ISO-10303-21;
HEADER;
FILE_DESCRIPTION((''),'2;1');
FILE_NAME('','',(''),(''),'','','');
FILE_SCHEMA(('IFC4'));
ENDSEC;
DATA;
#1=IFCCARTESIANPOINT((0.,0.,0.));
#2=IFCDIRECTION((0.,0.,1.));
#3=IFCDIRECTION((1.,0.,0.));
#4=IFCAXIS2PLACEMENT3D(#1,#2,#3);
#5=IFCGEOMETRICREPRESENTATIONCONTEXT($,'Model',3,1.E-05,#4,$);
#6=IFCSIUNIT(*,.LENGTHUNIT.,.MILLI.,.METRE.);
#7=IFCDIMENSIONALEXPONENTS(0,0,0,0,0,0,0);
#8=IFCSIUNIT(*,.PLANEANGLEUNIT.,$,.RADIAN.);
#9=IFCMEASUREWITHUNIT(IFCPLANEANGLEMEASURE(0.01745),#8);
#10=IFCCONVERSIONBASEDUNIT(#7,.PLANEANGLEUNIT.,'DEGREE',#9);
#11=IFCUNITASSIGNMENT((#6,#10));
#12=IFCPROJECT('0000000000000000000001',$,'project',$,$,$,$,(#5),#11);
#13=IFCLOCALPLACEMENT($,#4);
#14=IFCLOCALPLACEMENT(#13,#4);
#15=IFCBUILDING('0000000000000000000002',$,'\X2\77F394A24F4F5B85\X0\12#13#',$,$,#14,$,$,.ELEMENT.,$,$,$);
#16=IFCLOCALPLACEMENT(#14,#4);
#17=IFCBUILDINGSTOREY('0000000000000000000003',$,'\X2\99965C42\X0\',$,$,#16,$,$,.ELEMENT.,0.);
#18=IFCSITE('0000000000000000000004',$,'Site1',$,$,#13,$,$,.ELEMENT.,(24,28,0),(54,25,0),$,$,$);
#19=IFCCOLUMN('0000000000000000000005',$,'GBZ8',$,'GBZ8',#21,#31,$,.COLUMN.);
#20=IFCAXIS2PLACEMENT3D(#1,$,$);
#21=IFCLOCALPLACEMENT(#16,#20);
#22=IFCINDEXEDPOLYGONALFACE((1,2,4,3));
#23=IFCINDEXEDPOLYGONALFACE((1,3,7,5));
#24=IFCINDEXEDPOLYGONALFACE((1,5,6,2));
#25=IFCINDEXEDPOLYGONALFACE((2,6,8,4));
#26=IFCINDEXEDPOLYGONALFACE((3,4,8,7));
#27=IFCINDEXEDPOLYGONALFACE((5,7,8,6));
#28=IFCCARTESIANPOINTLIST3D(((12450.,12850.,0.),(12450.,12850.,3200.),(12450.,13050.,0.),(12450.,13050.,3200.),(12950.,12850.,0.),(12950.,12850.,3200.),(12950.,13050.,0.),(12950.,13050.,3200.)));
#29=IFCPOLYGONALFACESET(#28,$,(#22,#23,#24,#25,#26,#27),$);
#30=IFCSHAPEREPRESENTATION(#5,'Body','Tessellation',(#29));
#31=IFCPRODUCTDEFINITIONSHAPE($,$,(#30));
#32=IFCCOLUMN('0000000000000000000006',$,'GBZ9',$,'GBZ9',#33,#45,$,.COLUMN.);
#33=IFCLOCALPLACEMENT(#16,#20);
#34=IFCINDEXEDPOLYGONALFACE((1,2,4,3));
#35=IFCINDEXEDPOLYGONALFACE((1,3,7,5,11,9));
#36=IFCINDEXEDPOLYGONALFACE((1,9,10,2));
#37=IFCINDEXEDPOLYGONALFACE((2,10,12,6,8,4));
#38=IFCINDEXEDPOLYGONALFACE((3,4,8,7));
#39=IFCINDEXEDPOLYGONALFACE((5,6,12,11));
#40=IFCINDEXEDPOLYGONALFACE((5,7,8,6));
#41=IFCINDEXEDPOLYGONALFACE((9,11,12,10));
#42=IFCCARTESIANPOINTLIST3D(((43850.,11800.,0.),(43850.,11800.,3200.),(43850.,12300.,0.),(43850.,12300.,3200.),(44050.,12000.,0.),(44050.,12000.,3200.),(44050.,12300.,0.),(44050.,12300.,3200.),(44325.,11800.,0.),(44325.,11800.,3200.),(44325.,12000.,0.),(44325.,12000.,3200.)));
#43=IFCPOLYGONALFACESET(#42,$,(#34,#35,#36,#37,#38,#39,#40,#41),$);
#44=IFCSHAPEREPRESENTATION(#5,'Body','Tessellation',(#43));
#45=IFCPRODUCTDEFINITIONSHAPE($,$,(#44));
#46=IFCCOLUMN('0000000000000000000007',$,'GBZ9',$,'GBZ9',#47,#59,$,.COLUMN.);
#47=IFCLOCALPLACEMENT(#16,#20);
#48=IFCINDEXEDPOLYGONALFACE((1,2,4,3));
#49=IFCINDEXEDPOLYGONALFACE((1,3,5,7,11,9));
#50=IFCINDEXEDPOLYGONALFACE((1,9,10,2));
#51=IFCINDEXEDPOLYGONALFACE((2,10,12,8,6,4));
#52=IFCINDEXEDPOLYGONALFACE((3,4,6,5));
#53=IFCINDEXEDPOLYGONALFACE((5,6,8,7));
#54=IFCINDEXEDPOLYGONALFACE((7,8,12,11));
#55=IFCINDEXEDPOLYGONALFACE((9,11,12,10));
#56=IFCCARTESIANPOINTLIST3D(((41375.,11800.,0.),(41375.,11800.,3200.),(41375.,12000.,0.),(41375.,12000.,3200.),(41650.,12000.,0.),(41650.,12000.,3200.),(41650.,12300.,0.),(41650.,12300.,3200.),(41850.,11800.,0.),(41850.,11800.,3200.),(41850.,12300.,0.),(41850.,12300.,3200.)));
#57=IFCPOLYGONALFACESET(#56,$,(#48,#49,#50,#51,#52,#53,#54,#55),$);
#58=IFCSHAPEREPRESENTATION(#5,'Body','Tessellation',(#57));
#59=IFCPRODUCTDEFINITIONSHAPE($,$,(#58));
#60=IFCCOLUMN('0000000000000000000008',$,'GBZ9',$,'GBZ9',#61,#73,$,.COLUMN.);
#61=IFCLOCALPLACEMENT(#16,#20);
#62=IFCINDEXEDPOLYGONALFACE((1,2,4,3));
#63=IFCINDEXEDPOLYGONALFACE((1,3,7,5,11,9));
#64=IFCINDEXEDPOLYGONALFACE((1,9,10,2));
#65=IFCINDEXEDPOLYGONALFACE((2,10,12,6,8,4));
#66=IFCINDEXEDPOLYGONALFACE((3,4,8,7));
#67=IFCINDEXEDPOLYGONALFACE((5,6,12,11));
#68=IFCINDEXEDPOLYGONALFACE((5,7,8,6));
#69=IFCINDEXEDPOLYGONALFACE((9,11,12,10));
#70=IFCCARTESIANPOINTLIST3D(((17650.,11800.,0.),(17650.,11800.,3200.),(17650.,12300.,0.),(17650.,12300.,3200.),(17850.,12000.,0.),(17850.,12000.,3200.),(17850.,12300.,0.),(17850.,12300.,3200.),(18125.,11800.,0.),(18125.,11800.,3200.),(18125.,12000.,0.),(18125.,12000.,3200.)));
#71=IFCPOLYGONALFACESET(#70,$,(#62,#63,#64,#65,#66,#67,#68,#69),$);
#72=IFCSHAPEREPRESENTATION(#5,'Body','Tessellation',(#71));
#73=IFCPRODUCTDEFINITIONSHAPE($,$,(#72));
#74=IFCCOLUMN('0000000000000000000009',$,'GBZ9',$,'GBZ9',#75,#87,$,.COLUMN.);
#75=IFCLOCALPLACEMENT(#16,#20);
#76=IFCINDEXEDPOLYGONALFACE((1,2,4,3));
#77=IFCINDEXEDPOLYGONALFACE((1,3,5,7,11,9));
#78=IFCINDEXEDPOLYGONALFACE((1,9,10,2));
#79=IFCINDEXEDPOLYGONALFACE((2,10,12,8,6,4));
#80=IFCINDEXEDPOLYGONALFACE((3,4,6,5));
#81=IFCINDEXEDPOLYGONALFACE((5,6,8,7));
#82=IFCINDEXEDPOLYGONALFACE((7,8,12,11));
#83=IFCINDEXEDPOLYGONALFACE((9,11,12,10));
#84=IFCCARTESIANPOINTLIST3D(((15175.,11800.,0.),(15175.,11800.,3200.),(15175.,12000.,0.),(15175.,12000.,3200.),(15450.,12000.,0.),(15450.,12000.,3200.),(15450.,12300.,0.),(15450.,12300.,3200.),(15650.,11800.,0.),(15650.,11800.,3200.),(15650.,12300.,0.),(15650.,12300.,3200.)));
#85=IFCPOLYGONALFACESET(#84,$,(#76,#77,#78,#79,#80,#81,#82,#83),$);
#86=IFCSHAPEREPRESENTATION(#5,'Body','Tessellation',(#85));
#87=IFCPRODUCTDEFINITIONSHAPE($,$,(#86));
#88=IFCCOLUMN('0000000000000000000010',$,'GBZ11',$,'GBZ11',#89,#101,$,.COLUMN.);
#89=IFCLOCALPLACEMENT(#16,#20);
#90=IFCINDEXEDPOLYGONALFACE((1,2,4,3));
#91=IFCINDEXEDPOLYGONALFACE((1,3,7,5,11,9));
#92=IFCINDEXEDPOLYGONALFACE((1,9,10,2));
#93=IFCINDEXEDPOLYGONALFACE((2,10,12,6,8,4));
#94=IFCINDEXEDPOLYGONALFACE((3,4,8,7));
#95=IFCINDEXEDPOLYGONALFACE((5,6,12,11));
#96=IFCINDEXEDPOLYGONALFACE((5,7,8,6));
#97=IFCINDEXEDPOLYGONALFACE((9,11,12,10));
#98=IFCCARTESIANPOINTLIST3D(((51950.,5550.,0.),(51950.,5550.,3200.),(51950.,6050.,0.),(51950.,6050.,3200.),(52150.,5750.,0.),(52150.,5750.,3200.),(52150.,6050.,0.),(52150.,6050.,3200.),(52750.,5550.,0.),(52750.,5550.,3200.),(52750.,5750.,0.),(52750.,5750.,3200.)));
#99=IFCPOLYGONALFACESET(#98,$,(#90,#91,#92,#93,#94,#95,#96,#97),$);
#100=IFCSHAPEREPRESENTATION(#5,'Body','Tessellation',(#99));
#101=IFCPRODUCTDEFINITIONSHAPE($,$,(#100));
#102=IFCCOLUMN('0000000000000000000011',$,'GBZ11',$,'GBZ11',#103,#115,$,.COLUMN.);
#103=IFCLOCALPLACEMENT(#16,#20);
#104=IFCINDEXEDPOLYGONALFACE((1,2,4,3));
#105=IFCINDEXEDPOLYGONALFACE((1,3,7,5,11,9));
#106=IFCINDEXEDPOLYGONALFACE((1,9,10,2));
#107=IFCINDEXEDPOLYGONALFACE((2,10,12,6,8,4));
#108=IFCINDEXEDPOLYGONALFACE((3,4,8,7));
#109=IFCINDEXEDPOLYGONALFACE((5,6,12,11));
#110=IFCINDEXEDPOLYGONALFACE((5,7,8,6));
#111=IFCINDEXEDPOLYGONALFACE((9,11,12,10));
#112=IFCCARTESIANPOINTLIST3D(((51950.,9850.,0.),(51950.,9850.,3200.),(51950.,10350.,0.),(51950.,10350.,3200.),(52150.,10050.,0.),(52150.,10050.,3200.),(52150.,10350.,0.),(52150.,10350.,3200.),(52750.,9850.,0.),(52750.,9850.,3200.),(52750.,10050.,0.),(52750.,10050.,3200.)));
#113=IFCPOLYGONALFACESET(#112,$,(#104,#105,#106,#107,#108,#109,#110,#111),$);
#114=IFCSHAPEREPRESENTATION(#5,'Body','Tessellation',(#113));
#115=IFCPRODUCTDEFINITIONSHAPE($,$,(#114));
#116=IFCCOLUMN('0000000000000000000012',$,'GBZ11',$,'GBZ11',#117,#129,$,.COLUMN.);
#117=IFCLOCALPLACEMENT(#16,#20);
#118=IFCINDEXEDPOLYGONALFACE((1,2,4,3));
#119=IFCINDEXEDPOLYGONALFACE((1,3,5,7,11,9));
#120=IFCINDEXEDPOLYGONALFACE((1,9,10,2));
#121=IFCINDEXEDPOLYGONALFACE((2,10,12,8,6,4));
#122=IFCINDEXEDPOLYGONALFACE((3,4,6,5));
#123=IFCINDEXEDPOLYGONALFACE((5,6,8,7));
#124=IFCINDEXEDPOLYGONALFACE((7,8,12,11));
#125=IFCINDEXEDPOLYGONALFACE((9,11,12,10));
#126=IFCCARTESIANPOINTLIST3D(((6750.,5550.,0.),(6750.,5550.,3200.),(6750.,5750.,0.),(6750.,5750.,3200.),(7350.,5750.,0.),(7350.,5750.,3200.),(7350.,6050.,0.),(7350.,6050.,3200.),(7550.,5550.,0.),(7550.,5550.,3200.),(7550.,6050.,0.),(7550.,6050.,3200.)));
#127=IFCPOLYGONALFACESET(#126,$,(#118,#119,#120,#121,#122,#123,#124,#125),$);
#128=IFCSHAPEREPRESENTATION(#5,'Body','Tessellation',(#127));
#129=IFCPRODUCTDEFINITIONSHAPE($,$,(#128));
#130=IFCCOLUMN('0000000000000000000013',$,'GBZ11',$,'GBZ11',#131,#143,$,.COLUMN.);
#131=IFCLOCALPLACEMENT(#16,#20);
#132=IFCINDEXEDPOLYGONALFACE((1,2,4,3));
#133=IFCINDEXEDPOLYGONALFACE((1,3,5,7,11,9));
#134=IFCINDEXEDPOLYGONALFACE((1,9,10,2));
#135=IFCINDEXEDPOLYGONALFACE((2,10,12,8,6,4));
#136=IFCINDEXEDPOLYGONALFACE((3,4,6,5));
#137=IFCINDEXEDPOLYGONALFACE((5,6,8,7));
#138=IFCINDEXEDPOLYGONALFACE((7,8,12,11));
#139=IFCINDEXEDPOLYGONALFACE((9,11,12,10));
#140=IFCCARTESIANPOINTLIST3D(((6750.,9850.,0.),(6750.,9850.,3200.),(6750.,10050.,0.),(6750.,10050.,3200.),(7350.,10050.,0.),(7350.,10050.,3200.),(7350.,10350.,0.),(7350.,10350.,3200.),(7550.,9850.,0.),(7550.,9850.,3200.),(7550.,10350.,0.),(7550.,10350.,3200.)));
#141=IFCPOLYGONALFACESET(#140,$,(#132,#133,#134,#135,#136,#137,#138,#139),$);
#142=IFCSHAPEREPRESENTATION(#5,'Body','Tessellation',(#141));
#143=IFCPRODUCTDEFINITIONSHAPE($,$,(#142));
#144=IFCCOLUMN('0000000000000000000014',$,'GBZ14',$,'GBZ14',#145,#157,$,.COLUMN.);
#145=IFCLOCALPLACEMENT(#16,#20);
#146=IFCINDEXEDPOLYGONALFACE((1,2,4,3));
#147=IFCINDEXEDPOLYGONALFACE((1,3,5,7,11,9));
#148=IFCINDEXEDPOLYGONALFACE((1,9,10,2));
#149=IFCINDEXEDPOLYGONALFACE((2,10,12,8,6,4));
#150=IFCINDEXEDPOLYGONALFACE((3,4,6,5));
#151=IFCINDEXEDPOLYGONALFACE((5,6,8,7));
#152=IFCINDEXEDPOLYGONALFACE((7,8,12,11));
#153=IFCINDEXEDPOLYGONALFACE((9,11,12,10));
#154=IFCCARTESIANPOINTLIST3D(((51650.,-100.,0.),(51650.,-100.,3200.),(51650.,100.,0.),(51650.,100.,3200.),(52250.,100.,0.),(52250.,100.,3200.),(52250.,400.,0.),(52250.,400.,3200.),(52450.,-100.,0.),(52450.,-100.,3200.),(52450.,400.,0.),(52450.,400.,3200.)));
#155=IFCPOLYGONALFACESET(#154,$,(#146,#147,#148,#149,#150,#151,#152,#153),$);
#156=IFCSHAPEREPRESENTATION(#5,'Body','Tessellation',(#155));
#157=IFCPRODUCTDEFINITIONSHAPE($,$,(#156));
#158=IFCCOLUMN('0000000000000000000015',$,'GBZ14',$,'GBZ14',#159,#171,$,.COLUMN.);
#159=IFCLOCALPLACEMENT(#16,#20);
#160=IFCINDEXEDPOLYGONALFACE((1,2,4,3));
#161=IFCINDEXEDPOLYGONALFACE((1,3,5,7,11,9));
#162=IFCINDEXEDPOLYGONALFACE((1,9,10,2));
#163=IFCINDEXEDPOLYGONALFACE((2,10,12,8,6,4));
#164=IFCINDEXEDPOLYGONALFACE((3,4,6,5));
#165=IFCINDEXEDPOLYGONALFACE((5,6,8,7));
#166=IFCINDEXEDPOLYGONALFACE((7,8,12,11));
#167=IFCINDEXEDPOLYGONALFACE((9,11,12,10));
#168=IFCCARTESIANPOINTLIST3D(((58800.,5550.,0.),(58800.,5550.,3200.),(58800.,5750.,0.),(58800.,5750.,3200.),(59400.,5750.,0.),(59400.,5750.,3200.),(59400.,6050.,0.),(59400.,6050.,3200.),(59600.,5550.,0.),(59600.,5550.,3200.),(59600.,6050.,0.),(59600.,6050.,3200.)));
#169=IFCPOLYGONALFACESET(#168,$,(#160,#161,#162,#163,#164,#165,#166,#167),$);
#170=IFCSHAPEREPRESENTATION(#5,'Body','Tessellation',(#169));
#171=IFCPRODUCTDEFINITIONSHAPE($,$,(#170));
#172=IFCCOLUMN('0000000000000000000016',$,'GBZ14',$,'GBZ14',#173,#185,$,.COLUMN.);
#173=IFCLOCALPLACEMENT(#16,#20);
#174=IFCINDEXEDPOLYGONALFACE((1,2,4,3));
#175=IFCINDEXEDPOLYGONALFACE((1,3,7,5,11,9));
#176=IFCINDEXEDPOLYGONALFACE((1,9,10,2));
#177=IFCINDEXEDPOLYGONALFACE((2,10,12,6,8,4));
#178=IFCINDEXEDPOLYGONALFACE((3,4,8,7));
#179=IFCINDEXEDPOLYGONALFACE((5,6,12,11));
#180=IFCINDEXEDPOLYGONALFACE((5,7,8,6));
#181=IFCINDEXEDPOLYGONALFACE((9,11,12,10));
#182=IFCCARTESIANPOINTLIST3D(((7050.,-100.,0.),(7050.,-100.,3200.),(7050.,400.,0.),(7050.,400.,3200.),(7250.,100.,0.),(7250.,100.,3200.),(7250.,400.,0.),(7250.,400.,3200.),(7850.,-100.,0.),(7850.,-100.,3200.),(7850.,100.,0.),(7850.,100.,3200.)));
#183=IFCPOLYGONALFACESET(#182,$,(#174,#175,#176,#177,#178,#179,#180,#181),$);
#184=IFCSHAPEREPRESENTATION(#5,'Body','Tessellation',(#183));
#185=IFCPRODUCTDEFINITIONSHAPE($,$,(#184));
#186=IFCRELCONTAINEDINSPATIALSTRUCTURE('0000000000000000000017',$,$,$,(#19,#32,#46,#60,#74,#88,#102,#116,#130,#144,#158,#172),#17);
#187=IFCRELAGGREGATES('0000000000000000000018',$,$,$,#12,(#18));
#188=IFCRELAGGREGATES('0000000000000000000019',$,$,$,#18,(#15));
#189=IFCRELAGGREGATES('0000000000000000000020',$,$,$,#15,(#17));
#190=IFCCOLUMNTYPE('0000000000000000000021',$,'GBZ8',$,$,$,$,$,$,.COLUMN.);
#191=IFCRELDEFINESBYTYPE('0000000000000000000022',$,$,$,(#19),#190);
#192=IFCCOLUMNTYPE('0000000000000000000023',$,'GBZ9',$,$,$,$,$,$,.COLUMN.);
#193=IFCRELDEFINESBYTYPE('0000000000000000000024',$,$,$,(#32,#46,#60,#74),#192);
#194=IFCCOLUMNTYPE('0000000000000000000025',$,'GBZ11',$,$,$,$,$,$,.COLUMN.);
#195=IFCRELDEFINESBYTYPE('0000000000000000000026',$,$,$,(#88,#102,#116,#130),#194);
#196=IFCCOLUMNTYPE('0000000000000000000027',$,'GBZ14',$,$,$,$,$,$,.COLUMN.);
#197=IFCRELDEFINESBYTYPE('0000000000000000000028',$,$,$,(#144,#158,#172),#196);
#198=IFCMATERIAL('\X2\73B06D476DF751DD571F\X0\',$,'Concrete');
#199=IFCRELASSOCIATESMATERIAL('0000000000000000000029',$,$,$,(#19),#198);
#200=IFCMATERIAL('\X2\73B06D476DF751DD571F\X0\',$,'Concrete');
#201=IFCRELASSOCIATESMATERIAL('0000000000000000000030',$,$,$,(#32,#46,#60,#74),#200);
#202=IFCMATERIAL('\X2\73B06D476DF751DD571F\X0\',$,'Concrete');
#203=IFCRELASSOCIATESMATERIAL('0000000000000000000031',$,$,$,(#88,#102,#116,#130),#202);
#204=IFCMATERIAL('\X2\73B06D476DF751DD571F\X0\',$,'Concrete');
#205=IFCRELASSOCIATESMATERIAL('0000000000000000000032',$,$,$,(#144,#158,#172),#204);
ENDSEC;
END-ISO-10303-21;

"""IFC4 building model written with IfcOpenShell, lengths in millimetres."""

from ifc_helpers import new_model, entity, si_unit, converted_unit, frame, origin_with_axes, place, context, project, spatial, polyline, outline, extrude, material, type_object, element, save


model = new_model("IFC4")

# Units and contexts
model_context = context("Model", 3, precision=1e-05, world=origin_with_axes())
ifc_project = project(units=[si_unit("LENGTHUNIT", "METRE", prefix="MILLI"), converted_unit("PLANEANGLEUNIT", "DEGREE", entity("IfcPlaneAngleMeasure", 0.01745), si_unit("PLANEANGLEUNIT", "RADIAN"), dimensions=[0, 0, 0, 0, 0, 0, 0])], contexts=[model_context])

# Site, building, storey
site_placement = place(None, origin_with_axes())
site = spatial("IfcSite", under=ifc_project, at=site_placement, Name="Site1", CompositionType="ELEMENT", RefLatitude=(24, 28, 0), RefLongitude=(54, 25, 0))
building_placement = place(site_placement, origin_with_axes())
building = spatial("IfcBuilding", under=site, at=building_placement, Name="石钢住宅12#13#", CompositionType="ELEMENT")
storey_placement = place(building_placement, origin_with_axes())
storey = spatial("IfcBuildingStorey", under=building, at=storey_placement, Name="首层", CompositionType="ELEMENT", Elevation=0.0)

# Columns
ifc_material_1 = material(Name="现浇混凝土", Category="Concrete")
column_type_1 = type_object("IfcColumnType", Name="GBZ8", PredefinedType="COLUMN")
column_1_placement = place(storey_placement, origin_with_axes())
element("IfcColumn", 1, at=column_1_placement, inside=storey, type_object=column_type_1, material=ifc_material_1, Name="GBZ8", ObjectType="GBZ8", PredefinedType="COLUMN", context=model_context, shape_type="SweptSolid", body=[
    extrude(outline(polyline([(0.0, 0.0), (200.0, 0.0), (200.0, 500.0), (0.0, 500.0), (0.0, 0.0)])), frame((12950.0, 12850.0, 0.0), z_axis=(0.0, 0.0, 1.0), x_axis=(0.0, 1.0, 0.0)), (0.0, 0.0, 1.0), 3200.0),
])
ifc_material_2 = material(Name="现浇混凝土", Category="Concrete")
column_type_2 = type_object("IfcColumnType", Name="GBZ9", PredefinedType="COLUMN")
column_2_placement = place(storey_placement, origin_with_axes())
element("IfcColumn", 2, at=column_2_placement, inside=storey, type_object=column_type_2, material=ifc_material_2, Name="GBZ9", ObjectType="GBZ9", PredefinedType="COLUMN", context=model_context, shape_type="SweptSolid", body=[
    extrude(outline(polyline([(100.0, 100.0), (-375.0, 100.0), (-375.0, -100.0), (-100.0, -100.0), (-100.0, -400.0), (100.0, -400.0), (100.0, 100.0)])), frame((43950.0, 11900.0, 0.0), z_axis=(0.0, 0.0, 1.0), x_axis=(-1.0, 0.0, 0.0)), (0.0, 0.0, 1.0), 3200.0),
])
column_3_placement = place(storey_placement, origin_with_axes())
element("IfcColumn", 3, at=column_3_placement, inside=storey, type_object=column_type_2, material=ifc_material_2, Name="GBZ9", ObjectType="GBZ9", PredefinedType="COLUMN", context=model_context, shape_type="SweptSolid", body=[
    extrude(outline(polyline([(-100.0, 100.0), (-100.0, -400.0), (100.0, -400.0), (100.0, -100.0), (375.0, -100.0), (375.0, 100.0), (-100.0, 100.0)])), frame((41750.0, 11900.0, 0.0), z_axis=(0.0, 0.0, 1.0), x_axis=(-1.0, 0.0, 0.0)), (0.0, 0.0, 1.0), 3200.0),
])
column_4_placement = place(storey_placement, origin_with_axes())
element("IfcColumn", 4, at=column_4_placement, inside=storey, type_object=column_type_2, material=ifc_material_2, Name="GBZ9", ObjectType="GBZ9", PredefinedType="COLUMN", context=model_context, shape_type="SweptSolid", body=[
    extrude(outline(polyline([(-100.0, -100.0), (375.0, -100.0), (375.0, 100.0), (100.0, 100.0), (100.0, 400.0), (-100.0, 400.0), (-100.0, -100.0)])), frame((17750.0, 11900.0, 0.0), z_axis=(0.0, 0.0, 1.0), x_axis=(1.0, 0.0, 0.0)), (0.0, 0.0, 1.0), 3200.0),
])
column_5_placement = place(storey_placement, origin_with_axes())
element("IfcColumn", 5, at=column_5_placement, inside=storey, type_object=column_type_2, material=ifc_material_2, Name="GBZ9", ObjectType="GBZ9", PredefinedType="COLUMN", context=model_context, shape_type="SweptSolid", body=[
    extrude(outline(polyline([(100.0, -100.0), (100.0, 400.0), (-100.0, 400.0), (-100.0, 100.0), (-375.0, 100.0), (-375.0, -100.0), (100.0, -100.0)])), frame((15550.0, 11900.0, 0.0), z_axis=(0.0, 0.0, 1.0), x_axis=(1.0, 0.0, 0.0)), (0.0, 0.0, 1.0), 3200.0),
])
ifc_material_3 = material(Name="现浇混凝土", Category="Concrete")
column_type_3 = type_object("IfcColumnType", Name="GBZ11", PredefinedType="COLUMN")
column_6_placement = place(storey_placement, origin_with_axes())
element("IfcColumn", 6, at=column_6_placement, inside=storey, type_object=column_type_3, material=ifc_material_3, Name="GBZ11", ObjectType="GBZ11", PredefinedType="COLUMN", context=model_context, shape_type="SweptSolid", body=[
    extrude(outline(polyline([(100.0, -400.0), (100.0, 100.0), (-700.0, 100.0), (-700.0, -100.0), (-100.0, -100.0), (-100.0, -400.0), (100.0, -400.0)])), frame((52050.0, 5650.0, 0.0), z_axis=(0.0, 0.0, 1.0), x_axis=(-1.0, 0.0, 0.0)), (0.0, 0.0, 1.0), 3200.0),
])
column_7_placement = place(storey_placement, origin_with_axes())
element("IfcColumn", 7, at=column_7_placement, inside=storey, type_object=column_type_3, material=ifc_material_3, Name="GBZ11", ObjectType="GBZ11", PredefinedType="COLUMN", context=model_context, shape_type="SweptSolid", body=[
    extrude(outline(polyline([(100.0, -400.0), (100.0, 100.0), (-700.0, 100.0), (-700.0, -100.0), (-100.0, -100.0), (-100.0, -400.0), (100.0, -400.0)])), frame((52050.0, 9950.0, 0.0), z_axis=(0.0, 0.0, 1.0), x_axis=(-1.0, 0.0, 0.0)), (0.0, 0.0, 1.0), 3200.0),
])
column_8_placement = place(storey_placement, origin_with_axes())
element("IfcColumn", 8, at=column_8_placement, inside=storey, type_object=column_type_3, material=ifc_material_3, Name="GBZ11", ObjectType="GBZ11", PredefinedType="COLUMN", context=model_context, shape_type="SweptSolid", body=[
    extrude(outline(polyline([(100.0, 400.0), (-100.0, 400.0), (-100.0, 100.0), (-700.0, 100.0), (-700.0, -100.0), (100.0, -100.0), (100.0, 400.0)])), frame((7450.0, 5650.0, 0.0), z_axis=(0.0, 0.0, 1.0), x_axis=(1.0, 0.0, 0.0)), (0.0, 0.0, 1.0), 3200.0),
])
column_9_placement = place(storey_placement, origin_with_axes())
element("IfcColumn", 9, at=column_9_placement, inside=storey, type_object=column_type_3, material=ifc_material_3, Name="GBZ11", ObjectType="GBZ11", PredefinedType="COLUMN", context=model_context, shape_type="SweptSolid", body=[
    extrude(outline(polyline([(100.0, 400.0), (-100.0, 400.0), (-100.0, 100.0), (-700.0, 100.0), (-700.0, -100.0), (100.0, -100.0), (100.0, 400.0)])), frame((7450.0, 9950.0, 0.0), z_axis=(0.0, 0.0, 1.0), x_axis=(1.0, 0.0, 0.0)), (0.0, 0.0, 1.0), 3200.0),
])
ifc_material_4 = material(Name="现浇混凝土", Category="Concrete")
column_type_4 = type_object("IfcColumnType", Name="GBZ14", PredefinedType="COLUMN")
column_10_placement = place(storey_placement, origin_with_axes())
element("IfcColumn", 10, at=column_10_placement, inside=storey, type_object=column_type_4, material=ifc_material_4, Name="GBZ14", ObjectType="GBZ14", PredefinedType="COLUMN", context=model_context, shape_type="SweptSolid", body=[
    extrude(outline(polyline([(-100.0, -400.0), (100.0, -400.0), (100.0, -100.0), (700.0, -100.0), (700.0, 100.0), (-100.0, 100.0), (-100.0, -400.0)])), frame((52350.0, 0.0, 0.0), z_axis=(0.0, 0.0, 1.0), x_axis=(-1.0, 0.0, 0.0)), (0.0, 0.0, 1.0), 3200.0),
])
column_11_placement = place(storey_placement, origin_with_axes())
element("IfcColumn", 11, at=column_11_placement, inside=storey, type_object=column_type_4, material=ifc_material_4, Name="GBZ14", ObjectType="GBZ14", PredefinedType="COLUMN", context=model_context, shape_type="SweptSolid", body=[
    extrude(outline(polyline([(-100.0, -400.0), (100.0, -400.0), (100.0, -100.0), (700.0, -100.0), (700.0, 100.0), (-100.0, 100.0), (-100.0, -400.0)])), frame((59500.0, 5650.0, 0.0), z_axis=(0.0, 0.0, 1.0), x_axis=(-1.0, 0.0, 0.0)), (0.0, 0.0, 1.0), 3200.0),
])
column_12_placement = place(storey_placement, origin_with_axes())
element("IfcColumn", 12, at=column_12_placement, inside=storey, type_object=column_type_4, material=ifc_material_4, Name="GBZ14", ObjectType="GBZ14", PredefinedType="COLUMN", context=model_context, shape_type="SweptSolid", body=[
    extrude(outline(polyline([(-100.0, 400.0), (-100.0, -100.0), (700.0, -100.0), (700.0, 100.0), (100.0, 100.0), (100.0, 400.0), (-100.0, 400.0)])), frame((7150.0, 0.0, 0.0), z_axis=(0.0, 0.0, 1.0), x_axis=(1.0, 0.0, 0.0)), (0.0, 0.0, 1.0), 3200.0),
])

save(model, "model.ifc")
